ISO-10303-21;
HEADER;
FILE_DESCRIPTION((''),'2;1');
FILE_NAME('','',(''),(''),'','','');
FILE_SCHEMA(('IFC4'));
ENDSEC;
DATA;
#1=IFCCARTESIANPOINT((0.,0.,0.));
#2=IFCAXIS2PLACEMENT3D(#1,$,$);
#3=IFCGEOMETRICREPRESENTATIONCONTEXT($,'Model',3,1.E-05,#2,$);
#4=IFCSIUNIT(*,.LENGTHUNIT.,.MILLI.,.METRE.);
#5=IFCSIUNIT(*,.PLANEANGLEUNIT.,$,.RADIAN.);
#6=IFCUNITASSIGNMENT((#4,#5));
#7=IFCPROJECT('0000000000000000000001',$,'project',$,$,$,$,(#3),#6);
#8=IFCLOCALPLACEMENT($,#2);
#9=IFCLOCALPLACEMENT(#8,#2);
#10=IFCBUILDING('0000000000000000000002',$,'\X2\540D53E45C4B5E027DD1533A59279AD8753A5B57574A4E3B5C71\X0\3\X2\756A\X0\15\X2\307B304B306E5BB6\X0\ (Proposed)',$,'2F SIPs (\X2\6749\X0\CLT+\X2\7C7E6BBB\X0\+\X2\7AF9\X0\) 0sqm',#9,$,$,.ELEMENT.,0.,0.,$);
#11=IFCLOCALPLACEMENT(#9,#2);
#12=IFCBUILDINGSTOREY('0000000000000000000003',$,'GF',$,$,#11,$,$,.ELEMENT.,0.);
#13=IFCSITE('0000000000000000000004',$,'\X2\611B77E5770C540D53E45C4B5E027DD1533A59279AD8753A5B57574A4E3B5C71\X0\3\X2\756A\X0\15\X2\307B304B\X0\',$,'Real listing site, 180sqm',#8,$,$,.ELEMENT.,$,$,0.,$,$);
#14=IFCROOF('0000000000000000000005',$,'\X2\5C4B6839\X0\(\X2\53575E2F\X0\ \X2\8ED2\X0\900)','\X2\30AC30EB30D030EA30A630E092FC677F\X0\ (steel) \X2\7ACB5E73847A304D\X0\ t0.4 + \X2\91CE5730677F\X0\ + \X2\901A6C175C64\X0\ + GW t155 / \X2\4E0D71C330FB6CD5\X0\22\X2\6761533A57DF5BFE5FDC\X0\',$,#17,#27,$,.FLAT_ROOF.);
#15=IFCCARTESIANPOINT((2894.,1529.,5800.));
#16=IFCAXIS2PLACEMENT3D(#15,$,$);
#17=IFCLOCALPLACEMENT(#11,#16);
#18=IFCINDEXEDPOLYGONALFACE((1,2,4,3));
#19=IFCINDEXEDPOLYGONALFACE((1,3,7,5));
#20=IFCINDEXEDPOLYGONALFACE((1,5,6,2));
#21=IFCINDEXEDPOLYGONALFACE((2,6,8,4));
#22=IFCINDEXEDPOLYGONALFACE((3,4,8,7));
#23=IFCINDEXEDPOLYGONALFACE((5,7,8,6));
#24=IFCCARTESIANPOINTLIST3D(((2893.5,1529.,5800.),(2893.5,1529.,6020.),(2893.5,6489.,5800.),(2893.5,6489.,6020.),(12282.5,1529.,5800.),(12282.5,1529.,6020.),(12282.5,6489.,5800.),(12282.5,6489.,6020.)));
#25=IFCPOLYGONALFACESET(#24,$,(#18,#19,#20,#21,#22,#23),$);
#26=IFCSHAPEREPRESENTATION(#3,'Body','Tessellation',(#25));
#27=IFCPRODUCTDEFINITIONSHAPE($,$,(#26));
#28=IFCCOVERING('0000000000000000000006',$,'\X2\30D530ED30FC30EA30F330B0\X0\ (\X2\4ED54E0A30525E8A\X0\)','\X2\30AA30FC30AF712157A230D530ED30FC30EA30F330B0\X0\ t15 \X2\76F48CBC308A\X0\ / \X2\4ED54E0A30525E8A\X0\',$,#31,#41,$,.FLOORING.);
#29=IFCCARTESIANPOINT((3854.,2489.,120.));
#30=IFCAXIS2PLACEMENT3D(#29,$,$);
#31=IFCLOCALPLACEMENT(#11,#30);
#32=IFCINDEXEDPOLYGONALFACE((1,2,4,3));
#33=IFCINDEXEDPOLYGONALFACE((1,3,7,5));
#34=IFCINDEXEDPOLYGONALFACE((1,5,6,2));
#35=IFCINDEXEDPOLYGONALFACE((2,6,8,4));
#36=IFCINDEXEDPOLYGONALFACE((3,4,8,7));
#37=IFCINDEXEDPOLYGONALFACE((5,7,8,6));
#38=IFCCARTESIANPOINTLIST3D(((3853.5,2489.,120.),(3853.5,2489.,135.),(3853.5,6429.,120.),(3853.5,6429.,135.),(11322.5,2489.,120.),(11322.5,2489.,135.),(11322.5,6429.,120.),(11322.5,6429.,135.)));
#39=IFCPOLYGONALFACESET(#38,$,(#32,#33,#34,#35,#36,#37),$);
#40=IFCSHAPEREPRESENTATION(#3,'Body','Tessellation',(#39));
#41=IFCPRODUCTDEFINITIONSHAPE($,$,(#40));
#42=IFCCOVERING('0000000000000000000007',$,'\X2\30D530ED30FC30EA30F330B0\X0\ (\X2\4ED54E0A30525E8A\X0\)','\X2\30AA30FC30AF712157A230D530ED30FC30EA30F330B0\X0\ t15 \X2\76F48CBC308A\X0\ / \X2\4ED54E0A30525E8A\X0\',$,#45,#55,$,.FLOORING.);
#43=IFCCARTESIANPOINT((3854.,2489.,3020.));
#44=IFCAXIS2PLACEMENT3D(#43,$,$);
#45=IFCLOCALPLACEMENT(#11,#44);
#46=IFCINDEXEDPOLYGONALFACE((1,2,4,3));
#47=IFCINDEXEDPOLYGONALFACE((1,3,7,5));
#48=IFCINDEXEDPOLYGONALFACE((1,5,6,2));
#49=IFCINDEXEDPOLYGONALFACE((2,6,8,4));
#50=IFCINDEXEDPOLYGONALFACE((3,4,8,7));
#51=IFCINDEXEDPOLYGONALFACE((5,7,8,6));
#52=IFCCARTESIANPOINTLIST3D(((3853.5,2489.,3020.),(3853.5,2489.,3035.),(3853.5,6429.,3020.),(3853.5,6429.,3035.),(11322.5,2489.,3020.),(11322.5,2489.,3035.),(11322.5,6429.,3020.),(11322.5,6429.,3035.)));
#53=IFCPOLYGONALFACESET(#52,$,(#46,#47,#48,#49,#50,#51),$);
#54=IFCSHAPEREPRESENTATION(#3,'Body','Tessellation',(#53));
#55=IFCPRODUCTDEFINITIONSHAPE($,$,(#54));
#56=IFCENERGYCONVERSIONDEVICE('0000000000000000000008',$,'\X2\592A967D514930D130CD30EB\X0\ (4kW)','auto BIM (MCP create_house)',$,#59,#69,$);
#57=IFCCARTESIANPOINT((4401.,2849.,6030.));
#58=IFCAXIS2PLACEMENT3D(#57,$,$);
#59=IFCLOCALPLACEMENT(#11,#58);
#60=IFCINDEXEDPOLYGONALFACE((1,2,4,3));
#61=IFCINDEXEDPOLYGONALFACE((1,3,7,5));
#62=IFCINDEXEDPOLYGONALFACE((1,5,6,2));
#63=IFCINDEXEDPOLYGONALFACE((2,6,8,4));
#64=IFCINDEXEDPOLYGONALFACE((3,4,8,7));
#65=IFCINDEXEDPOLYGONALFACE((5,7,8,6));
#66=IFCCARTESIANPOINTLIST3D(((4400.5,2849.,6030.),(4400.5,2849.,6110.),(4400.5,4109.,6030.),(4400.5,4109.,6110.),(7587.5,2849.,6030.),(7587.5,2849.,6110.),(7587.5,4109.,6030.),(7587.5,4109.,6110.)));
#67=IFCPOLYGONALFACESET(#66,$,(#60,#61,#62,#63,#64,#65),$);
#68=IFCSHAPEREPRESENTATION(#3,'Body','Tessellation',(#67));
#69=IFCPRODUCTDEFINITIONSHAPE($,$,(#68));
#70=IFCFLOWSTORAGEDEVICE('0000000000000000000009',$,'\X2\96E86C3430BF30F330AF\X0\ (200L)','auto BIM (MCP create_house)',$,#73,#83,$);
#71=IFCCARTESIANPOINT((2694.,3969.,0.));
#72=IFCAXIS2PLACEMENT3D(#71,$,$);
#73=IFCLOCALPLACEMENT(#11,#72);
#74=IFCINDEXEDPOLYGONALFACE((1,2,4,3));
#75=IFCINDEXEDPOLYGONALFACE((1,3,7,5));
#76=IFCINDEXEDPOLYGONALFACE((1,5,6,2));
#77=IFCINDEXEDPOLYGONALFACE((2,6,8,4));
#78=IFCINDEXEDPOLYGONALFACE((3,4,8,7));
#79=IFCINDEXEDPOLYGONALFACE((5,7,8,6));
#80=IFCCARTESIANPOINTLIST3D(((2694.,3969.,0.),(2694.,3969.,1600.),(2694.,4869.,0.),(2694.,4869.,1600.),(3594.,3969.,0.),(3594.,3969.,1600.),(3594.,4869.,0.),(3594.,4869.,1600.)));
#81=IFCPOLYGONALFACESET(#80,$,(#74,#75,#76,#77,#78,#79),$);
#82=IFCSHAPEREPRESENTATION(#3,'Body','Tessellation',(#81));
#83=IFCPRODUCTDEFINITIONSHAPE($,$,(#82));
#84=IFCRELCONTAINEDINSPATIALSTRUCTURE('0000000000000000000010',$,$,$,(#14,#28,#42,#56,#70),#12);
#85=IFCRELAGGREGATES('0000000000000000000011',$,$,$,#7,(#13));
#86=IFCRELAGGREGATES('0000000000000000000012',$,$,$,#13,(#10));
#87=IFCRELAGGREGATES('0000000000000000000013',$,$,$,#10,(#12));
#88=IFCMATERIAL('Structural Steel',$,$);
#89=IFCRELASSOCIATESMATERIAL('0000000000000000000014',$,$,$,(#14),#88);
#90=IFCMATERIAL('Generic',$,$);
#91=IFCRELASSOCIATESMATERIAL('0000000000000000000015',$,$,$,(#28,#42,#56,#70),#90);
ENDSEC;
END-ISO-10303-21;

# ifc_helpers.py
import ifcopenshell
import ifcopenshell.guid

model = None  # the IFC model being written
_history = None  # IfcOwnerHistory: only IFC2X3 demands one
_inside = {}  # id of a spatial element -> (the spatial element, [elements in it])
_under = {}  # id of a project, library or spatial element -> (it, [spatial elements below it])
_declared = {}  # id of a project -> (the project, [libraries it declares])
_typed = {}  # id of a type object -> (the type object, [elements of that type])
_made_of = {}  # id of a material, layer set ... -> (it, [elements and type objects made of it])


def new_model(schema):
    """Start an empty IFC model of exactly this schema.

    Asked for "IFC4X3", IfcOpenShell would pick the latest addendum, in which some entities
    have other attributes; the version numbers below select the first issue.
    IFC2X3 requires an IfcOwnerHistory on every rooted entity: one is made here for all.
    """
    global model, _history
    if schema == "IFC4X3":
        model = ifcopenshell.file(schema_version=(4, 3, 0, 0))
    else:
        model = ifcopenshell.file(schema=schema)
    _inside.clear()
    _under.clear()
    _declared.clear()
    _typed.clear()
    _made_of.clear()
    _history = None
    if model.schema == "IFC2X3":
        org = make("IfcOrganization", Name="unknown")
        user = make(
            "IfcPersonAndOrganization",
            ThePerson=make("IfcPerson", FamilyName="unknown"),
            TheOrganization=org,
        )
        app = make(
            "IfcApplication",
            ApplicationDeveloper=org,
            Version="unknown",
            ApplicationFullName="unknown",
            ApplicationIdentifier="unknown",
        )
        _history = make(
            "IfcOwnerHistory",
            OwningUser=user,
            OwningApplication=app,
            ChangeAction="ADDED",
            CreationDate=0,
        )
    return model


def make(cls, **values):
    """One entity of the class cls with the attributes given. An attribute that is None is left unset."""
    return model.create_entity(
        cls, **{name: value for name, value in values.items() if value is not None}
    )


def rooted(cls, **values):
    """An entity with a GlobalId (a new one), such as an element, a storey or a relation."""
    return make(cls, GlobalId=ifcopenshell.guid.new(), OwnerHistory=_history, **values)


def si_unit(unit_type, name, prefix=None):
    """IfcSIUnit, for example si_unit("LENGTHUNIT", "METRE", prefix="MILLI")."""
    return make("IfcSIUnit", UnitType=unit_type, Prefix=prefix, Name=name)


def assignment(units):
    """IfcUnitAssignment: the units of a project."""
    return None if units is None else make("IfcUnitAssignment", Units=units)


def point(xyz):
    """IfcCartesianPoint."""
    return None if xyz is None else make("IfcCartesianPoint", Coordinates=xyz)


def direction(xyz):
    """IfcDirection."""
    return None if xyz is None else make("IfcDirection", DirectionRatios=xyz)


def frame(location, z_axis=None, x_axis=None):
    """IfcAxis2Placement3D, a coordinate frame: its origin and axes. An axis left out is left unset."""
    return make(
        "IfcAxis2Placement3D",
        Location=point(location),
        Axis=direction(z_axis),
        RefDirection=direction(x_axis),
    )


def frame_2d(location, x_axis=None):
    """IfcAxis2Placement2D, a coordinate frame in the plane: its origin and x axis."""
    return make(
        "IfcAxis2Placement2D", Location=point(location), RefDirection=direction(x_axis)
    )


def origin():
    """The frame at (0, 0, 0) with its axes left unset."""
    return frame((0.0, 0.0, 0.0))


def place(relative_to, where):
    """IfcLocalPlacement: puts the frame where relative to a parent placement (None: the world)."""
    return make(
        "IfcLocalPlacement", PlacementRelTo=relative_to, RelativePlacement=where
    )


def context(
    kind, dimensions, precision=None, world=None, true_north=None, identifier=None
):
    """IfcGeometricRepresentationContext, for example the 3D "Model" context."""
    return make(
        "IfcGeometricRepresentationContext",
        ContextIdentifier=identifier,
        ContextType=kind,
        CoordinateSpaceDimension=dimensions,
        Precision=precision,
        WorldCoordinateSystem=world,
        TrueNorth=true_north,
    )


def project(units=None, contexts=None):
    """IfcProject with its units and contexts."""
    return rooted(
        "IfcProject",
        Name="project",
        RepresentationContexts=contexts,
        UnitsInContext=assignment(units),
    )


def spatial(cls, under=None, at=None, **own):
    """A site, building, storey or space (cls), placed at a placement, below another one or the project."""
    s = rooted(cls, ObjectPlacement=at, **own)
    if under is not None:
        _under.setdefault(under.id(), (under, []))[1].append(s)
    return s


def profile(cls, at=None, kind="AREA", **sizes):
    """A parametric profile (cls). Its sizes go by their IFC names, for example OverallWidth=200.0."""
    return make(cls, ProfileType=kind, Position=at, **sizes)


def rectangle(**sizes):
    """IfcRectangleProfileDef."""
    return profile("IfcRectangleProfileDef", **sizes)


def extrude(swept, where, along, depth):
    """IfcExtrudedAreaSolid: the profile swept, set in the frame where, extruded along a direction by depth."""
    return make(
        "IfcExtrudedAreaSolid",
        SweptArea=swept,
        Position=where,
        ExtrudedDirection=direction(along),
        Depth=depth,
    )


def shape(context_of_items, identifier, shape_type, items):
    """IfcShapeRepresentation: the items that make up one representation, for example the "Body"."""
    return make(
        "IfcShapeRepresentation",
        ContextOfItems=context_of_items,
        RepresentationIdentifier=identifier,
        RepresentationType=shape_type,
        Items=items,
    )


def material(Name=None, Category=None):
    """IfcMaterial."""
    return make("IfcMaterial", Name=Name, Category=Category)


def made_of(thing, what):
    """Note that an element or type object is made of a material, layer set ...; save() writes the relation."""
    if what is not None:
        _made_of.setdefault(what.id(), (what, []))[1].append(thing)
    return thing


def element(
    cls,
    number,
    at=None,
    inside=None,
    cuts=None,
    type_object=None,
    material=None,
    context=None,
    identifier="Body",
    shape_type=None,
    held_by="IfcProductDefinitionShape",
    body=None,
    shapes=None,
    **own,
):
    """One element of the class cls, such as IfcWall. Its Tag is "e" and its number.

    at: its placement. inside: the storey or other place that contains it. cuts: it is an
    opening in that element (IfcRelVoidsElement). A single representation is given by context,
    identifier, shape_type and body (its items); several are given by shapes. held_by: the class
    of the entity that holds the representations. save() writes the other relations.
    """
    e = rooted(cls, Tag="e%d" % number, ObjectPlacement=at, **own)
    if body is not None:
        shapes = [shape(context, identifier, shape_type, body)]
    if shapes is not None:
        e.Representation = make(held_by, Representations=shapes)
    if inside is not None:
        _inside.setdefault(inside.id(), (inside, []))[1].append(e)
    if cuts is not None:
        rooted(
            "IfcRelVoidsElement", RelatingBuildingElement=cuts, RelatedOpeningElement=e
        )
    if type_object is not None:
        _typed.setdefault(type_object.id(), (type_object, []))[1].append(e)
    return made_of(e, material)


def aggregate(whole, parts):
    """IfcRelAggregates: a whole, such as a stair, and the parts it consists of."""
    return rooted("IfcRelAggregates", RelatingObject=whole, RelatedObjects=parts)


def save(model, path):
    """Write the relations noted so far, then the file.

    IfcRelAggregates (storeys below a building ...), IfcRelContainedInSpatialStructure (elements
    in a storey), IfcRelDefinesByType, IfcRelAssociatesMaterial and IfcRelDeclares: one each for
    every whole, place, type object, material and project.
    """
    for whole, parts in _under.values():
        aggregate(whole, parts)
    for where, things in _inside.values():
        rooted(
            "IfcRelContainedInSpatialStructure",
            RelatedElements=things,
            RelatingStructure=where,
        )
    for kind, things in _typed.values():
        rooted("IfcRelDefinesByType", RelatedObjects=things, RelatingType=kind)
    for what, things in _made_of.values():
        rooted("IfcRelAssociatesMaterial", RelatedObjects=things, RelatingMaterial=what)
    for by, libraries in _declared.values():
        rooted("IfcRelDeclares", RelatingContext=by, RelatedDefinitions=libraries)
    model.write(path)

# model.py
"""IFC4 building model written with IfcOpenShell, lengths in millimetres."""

from ifc_helpers import new_model, si_unit, frame, frame_2d, origin, place, context, project, spatial, rectangle, extrude, material, element, save


model = new_model("IFC4")

# Units and contexts
model_context = context("Model", 3, precision=1e-05, world=origin())
ifc_project = project(units=[si_unit("LENGTHUNIT", "METRE", prefix="MILLI"), si_unit("PLANEANGLEUNIT", "RADIAN")], contexts=[model_context])

# Site, building, storey
site_placement = place(None, origin())
site = spatial("IfcSite", under=ifc_project, at=site_placement, Name="愛知県名古屋市緑区大高町字坊主山3番15ほか", ObjectType="Real listing site, 180sqm", CompositionType="ELEMENT", RefElevation=0.0)
building_placement = place(site_placement, origin())
building = spatial("IfcBuilding", under=site, at=building_placement, Name="名古屋市緑区大高町字坊主山3番15ほかの家 (Proposed)", ObjectType="2F SIPs (杉CLT+籾殻+竹) 0sqm", CompositionType="ELEMENT", ElevationOfRefHeight=0.0, ElevationOfTerrain=0.0)
storey_placement = place(building_placement, origin())
storey = spatial("IfcBuildingStorey", under=building, at=storey_placement, Name="GF", CompositionType="ELEMENT", Elevation=0.0)

# Roof
ifc_material_1 = material(Name="Structural Steel")
for number, where, name in (
    (1, (2894.0, 1529.0, 5800.0), "屋根(南帯 軒900)"),
):
    element("IfcRoof", number, at=place(storey_placement, frame(where)), inside=storey, material=ifc_material_1, Name=name, Description="ガルバリウム鋼板 (steel) 立平葺き t0.4 + 野地板 + 通気層 + GW t155 / 不燃・法22条区域対応", PredefinedType="FLAT_ROOF", context=model_context, shape_type="SweptSolid", body=[
        extrude(rectangle(XDim=9389.0, YDim=4960.0, at=frame_2d((4694.0, 2480.0))), frame((2894.0, 1529.0, 5800.0)), (0.0, 0.0, 1.0), 220.0),
    ])

# Coverings
ifc_material_2 = material(Name="Generic")
covering_1_placement = place(storey_placement, frame((3854.0, 2489.0, 120.0)))
element("IfcCovering", 2, at=covering_1_placement, inside=storey, material=ifc_material_2, Name="フローリング (仕上げ床)", Description="オーク無垢フローリング t15 直貼り / 仕上げ床", PredefinedType="FLOORING", context=model_context, shape_type="SweptSolid", body=[
    extrude(rectangle(XDim=7469.0, YDim=3940.0, at=frame_2d((3734.0, 1970.0))), frame((3854.0, 2489.0, 120.0)), (0.0, 0.0, 1.0), 15.0),
])
covering_2_placement = place(storey_placement, frame((3854.0, 2489.0, 3020.0)))
element("IfcCovering", 3, at=covering_2_placement, inside=storey, material=ifc_material_2, Name="フローリング (仕上げ床)", Description="オーク無垢フローリング t15 直貼り / 仕上げ床", PredefinedType="FLOORING", context=model_context, shape_type="SweptSolid", body=[
    extrude(rectangle(XDim=7469.0, YDim=3940.0, at=frame_2d((3734.0, 1970.0))), frame((3854.0, 2489.0, 3020.0)), (0.0, 0.0, 1.0), 15.0),
])

# Energy conversion device
energy_conversion_device_placement = place(storey_placement, frame((4401.0, 2849.0, 6030.0)))
element("IfcEnergyConversionDevice", 4, at=energy_conversion_device_placement, inside=storey, material=ifc_material_2, Name="太陽光パネル (4kW)", Description="auto BIM (MCP create_house)", context=model_context, shape_type="SweptSolid", body=[
    extrude(rectangle(XDim=3187.0, YDim=1260.0, at=frame_2d((1593.0, 630.0))), frame((4401.0, 2849.0, 6030.0)), (0.0, 0.0, 1.0), 80.0),
])

# Flow storage device
flow_storage_device_placement = place(storey_placement, frame((2694.0, 3969.0, 0.0)))
element("IfcFlowStorageDevice", 5, at=flow_storage_device_placement, inside=storey, material=ifc_material_2, Name="雨水タンク (200L)", Description="auto BIM (MCP create_house)", context=model_context, shape_type="SweptSolid", body=[
    extrude(rectangle(XDim=900.0, YDim=900.0, at=frame_2d((450.0, 450.0))), frame((2694.0, 3969.0, 0.0)), (0.0, 0.0, 1.0), 1600.0),
])

save(model, "model.ifc")
